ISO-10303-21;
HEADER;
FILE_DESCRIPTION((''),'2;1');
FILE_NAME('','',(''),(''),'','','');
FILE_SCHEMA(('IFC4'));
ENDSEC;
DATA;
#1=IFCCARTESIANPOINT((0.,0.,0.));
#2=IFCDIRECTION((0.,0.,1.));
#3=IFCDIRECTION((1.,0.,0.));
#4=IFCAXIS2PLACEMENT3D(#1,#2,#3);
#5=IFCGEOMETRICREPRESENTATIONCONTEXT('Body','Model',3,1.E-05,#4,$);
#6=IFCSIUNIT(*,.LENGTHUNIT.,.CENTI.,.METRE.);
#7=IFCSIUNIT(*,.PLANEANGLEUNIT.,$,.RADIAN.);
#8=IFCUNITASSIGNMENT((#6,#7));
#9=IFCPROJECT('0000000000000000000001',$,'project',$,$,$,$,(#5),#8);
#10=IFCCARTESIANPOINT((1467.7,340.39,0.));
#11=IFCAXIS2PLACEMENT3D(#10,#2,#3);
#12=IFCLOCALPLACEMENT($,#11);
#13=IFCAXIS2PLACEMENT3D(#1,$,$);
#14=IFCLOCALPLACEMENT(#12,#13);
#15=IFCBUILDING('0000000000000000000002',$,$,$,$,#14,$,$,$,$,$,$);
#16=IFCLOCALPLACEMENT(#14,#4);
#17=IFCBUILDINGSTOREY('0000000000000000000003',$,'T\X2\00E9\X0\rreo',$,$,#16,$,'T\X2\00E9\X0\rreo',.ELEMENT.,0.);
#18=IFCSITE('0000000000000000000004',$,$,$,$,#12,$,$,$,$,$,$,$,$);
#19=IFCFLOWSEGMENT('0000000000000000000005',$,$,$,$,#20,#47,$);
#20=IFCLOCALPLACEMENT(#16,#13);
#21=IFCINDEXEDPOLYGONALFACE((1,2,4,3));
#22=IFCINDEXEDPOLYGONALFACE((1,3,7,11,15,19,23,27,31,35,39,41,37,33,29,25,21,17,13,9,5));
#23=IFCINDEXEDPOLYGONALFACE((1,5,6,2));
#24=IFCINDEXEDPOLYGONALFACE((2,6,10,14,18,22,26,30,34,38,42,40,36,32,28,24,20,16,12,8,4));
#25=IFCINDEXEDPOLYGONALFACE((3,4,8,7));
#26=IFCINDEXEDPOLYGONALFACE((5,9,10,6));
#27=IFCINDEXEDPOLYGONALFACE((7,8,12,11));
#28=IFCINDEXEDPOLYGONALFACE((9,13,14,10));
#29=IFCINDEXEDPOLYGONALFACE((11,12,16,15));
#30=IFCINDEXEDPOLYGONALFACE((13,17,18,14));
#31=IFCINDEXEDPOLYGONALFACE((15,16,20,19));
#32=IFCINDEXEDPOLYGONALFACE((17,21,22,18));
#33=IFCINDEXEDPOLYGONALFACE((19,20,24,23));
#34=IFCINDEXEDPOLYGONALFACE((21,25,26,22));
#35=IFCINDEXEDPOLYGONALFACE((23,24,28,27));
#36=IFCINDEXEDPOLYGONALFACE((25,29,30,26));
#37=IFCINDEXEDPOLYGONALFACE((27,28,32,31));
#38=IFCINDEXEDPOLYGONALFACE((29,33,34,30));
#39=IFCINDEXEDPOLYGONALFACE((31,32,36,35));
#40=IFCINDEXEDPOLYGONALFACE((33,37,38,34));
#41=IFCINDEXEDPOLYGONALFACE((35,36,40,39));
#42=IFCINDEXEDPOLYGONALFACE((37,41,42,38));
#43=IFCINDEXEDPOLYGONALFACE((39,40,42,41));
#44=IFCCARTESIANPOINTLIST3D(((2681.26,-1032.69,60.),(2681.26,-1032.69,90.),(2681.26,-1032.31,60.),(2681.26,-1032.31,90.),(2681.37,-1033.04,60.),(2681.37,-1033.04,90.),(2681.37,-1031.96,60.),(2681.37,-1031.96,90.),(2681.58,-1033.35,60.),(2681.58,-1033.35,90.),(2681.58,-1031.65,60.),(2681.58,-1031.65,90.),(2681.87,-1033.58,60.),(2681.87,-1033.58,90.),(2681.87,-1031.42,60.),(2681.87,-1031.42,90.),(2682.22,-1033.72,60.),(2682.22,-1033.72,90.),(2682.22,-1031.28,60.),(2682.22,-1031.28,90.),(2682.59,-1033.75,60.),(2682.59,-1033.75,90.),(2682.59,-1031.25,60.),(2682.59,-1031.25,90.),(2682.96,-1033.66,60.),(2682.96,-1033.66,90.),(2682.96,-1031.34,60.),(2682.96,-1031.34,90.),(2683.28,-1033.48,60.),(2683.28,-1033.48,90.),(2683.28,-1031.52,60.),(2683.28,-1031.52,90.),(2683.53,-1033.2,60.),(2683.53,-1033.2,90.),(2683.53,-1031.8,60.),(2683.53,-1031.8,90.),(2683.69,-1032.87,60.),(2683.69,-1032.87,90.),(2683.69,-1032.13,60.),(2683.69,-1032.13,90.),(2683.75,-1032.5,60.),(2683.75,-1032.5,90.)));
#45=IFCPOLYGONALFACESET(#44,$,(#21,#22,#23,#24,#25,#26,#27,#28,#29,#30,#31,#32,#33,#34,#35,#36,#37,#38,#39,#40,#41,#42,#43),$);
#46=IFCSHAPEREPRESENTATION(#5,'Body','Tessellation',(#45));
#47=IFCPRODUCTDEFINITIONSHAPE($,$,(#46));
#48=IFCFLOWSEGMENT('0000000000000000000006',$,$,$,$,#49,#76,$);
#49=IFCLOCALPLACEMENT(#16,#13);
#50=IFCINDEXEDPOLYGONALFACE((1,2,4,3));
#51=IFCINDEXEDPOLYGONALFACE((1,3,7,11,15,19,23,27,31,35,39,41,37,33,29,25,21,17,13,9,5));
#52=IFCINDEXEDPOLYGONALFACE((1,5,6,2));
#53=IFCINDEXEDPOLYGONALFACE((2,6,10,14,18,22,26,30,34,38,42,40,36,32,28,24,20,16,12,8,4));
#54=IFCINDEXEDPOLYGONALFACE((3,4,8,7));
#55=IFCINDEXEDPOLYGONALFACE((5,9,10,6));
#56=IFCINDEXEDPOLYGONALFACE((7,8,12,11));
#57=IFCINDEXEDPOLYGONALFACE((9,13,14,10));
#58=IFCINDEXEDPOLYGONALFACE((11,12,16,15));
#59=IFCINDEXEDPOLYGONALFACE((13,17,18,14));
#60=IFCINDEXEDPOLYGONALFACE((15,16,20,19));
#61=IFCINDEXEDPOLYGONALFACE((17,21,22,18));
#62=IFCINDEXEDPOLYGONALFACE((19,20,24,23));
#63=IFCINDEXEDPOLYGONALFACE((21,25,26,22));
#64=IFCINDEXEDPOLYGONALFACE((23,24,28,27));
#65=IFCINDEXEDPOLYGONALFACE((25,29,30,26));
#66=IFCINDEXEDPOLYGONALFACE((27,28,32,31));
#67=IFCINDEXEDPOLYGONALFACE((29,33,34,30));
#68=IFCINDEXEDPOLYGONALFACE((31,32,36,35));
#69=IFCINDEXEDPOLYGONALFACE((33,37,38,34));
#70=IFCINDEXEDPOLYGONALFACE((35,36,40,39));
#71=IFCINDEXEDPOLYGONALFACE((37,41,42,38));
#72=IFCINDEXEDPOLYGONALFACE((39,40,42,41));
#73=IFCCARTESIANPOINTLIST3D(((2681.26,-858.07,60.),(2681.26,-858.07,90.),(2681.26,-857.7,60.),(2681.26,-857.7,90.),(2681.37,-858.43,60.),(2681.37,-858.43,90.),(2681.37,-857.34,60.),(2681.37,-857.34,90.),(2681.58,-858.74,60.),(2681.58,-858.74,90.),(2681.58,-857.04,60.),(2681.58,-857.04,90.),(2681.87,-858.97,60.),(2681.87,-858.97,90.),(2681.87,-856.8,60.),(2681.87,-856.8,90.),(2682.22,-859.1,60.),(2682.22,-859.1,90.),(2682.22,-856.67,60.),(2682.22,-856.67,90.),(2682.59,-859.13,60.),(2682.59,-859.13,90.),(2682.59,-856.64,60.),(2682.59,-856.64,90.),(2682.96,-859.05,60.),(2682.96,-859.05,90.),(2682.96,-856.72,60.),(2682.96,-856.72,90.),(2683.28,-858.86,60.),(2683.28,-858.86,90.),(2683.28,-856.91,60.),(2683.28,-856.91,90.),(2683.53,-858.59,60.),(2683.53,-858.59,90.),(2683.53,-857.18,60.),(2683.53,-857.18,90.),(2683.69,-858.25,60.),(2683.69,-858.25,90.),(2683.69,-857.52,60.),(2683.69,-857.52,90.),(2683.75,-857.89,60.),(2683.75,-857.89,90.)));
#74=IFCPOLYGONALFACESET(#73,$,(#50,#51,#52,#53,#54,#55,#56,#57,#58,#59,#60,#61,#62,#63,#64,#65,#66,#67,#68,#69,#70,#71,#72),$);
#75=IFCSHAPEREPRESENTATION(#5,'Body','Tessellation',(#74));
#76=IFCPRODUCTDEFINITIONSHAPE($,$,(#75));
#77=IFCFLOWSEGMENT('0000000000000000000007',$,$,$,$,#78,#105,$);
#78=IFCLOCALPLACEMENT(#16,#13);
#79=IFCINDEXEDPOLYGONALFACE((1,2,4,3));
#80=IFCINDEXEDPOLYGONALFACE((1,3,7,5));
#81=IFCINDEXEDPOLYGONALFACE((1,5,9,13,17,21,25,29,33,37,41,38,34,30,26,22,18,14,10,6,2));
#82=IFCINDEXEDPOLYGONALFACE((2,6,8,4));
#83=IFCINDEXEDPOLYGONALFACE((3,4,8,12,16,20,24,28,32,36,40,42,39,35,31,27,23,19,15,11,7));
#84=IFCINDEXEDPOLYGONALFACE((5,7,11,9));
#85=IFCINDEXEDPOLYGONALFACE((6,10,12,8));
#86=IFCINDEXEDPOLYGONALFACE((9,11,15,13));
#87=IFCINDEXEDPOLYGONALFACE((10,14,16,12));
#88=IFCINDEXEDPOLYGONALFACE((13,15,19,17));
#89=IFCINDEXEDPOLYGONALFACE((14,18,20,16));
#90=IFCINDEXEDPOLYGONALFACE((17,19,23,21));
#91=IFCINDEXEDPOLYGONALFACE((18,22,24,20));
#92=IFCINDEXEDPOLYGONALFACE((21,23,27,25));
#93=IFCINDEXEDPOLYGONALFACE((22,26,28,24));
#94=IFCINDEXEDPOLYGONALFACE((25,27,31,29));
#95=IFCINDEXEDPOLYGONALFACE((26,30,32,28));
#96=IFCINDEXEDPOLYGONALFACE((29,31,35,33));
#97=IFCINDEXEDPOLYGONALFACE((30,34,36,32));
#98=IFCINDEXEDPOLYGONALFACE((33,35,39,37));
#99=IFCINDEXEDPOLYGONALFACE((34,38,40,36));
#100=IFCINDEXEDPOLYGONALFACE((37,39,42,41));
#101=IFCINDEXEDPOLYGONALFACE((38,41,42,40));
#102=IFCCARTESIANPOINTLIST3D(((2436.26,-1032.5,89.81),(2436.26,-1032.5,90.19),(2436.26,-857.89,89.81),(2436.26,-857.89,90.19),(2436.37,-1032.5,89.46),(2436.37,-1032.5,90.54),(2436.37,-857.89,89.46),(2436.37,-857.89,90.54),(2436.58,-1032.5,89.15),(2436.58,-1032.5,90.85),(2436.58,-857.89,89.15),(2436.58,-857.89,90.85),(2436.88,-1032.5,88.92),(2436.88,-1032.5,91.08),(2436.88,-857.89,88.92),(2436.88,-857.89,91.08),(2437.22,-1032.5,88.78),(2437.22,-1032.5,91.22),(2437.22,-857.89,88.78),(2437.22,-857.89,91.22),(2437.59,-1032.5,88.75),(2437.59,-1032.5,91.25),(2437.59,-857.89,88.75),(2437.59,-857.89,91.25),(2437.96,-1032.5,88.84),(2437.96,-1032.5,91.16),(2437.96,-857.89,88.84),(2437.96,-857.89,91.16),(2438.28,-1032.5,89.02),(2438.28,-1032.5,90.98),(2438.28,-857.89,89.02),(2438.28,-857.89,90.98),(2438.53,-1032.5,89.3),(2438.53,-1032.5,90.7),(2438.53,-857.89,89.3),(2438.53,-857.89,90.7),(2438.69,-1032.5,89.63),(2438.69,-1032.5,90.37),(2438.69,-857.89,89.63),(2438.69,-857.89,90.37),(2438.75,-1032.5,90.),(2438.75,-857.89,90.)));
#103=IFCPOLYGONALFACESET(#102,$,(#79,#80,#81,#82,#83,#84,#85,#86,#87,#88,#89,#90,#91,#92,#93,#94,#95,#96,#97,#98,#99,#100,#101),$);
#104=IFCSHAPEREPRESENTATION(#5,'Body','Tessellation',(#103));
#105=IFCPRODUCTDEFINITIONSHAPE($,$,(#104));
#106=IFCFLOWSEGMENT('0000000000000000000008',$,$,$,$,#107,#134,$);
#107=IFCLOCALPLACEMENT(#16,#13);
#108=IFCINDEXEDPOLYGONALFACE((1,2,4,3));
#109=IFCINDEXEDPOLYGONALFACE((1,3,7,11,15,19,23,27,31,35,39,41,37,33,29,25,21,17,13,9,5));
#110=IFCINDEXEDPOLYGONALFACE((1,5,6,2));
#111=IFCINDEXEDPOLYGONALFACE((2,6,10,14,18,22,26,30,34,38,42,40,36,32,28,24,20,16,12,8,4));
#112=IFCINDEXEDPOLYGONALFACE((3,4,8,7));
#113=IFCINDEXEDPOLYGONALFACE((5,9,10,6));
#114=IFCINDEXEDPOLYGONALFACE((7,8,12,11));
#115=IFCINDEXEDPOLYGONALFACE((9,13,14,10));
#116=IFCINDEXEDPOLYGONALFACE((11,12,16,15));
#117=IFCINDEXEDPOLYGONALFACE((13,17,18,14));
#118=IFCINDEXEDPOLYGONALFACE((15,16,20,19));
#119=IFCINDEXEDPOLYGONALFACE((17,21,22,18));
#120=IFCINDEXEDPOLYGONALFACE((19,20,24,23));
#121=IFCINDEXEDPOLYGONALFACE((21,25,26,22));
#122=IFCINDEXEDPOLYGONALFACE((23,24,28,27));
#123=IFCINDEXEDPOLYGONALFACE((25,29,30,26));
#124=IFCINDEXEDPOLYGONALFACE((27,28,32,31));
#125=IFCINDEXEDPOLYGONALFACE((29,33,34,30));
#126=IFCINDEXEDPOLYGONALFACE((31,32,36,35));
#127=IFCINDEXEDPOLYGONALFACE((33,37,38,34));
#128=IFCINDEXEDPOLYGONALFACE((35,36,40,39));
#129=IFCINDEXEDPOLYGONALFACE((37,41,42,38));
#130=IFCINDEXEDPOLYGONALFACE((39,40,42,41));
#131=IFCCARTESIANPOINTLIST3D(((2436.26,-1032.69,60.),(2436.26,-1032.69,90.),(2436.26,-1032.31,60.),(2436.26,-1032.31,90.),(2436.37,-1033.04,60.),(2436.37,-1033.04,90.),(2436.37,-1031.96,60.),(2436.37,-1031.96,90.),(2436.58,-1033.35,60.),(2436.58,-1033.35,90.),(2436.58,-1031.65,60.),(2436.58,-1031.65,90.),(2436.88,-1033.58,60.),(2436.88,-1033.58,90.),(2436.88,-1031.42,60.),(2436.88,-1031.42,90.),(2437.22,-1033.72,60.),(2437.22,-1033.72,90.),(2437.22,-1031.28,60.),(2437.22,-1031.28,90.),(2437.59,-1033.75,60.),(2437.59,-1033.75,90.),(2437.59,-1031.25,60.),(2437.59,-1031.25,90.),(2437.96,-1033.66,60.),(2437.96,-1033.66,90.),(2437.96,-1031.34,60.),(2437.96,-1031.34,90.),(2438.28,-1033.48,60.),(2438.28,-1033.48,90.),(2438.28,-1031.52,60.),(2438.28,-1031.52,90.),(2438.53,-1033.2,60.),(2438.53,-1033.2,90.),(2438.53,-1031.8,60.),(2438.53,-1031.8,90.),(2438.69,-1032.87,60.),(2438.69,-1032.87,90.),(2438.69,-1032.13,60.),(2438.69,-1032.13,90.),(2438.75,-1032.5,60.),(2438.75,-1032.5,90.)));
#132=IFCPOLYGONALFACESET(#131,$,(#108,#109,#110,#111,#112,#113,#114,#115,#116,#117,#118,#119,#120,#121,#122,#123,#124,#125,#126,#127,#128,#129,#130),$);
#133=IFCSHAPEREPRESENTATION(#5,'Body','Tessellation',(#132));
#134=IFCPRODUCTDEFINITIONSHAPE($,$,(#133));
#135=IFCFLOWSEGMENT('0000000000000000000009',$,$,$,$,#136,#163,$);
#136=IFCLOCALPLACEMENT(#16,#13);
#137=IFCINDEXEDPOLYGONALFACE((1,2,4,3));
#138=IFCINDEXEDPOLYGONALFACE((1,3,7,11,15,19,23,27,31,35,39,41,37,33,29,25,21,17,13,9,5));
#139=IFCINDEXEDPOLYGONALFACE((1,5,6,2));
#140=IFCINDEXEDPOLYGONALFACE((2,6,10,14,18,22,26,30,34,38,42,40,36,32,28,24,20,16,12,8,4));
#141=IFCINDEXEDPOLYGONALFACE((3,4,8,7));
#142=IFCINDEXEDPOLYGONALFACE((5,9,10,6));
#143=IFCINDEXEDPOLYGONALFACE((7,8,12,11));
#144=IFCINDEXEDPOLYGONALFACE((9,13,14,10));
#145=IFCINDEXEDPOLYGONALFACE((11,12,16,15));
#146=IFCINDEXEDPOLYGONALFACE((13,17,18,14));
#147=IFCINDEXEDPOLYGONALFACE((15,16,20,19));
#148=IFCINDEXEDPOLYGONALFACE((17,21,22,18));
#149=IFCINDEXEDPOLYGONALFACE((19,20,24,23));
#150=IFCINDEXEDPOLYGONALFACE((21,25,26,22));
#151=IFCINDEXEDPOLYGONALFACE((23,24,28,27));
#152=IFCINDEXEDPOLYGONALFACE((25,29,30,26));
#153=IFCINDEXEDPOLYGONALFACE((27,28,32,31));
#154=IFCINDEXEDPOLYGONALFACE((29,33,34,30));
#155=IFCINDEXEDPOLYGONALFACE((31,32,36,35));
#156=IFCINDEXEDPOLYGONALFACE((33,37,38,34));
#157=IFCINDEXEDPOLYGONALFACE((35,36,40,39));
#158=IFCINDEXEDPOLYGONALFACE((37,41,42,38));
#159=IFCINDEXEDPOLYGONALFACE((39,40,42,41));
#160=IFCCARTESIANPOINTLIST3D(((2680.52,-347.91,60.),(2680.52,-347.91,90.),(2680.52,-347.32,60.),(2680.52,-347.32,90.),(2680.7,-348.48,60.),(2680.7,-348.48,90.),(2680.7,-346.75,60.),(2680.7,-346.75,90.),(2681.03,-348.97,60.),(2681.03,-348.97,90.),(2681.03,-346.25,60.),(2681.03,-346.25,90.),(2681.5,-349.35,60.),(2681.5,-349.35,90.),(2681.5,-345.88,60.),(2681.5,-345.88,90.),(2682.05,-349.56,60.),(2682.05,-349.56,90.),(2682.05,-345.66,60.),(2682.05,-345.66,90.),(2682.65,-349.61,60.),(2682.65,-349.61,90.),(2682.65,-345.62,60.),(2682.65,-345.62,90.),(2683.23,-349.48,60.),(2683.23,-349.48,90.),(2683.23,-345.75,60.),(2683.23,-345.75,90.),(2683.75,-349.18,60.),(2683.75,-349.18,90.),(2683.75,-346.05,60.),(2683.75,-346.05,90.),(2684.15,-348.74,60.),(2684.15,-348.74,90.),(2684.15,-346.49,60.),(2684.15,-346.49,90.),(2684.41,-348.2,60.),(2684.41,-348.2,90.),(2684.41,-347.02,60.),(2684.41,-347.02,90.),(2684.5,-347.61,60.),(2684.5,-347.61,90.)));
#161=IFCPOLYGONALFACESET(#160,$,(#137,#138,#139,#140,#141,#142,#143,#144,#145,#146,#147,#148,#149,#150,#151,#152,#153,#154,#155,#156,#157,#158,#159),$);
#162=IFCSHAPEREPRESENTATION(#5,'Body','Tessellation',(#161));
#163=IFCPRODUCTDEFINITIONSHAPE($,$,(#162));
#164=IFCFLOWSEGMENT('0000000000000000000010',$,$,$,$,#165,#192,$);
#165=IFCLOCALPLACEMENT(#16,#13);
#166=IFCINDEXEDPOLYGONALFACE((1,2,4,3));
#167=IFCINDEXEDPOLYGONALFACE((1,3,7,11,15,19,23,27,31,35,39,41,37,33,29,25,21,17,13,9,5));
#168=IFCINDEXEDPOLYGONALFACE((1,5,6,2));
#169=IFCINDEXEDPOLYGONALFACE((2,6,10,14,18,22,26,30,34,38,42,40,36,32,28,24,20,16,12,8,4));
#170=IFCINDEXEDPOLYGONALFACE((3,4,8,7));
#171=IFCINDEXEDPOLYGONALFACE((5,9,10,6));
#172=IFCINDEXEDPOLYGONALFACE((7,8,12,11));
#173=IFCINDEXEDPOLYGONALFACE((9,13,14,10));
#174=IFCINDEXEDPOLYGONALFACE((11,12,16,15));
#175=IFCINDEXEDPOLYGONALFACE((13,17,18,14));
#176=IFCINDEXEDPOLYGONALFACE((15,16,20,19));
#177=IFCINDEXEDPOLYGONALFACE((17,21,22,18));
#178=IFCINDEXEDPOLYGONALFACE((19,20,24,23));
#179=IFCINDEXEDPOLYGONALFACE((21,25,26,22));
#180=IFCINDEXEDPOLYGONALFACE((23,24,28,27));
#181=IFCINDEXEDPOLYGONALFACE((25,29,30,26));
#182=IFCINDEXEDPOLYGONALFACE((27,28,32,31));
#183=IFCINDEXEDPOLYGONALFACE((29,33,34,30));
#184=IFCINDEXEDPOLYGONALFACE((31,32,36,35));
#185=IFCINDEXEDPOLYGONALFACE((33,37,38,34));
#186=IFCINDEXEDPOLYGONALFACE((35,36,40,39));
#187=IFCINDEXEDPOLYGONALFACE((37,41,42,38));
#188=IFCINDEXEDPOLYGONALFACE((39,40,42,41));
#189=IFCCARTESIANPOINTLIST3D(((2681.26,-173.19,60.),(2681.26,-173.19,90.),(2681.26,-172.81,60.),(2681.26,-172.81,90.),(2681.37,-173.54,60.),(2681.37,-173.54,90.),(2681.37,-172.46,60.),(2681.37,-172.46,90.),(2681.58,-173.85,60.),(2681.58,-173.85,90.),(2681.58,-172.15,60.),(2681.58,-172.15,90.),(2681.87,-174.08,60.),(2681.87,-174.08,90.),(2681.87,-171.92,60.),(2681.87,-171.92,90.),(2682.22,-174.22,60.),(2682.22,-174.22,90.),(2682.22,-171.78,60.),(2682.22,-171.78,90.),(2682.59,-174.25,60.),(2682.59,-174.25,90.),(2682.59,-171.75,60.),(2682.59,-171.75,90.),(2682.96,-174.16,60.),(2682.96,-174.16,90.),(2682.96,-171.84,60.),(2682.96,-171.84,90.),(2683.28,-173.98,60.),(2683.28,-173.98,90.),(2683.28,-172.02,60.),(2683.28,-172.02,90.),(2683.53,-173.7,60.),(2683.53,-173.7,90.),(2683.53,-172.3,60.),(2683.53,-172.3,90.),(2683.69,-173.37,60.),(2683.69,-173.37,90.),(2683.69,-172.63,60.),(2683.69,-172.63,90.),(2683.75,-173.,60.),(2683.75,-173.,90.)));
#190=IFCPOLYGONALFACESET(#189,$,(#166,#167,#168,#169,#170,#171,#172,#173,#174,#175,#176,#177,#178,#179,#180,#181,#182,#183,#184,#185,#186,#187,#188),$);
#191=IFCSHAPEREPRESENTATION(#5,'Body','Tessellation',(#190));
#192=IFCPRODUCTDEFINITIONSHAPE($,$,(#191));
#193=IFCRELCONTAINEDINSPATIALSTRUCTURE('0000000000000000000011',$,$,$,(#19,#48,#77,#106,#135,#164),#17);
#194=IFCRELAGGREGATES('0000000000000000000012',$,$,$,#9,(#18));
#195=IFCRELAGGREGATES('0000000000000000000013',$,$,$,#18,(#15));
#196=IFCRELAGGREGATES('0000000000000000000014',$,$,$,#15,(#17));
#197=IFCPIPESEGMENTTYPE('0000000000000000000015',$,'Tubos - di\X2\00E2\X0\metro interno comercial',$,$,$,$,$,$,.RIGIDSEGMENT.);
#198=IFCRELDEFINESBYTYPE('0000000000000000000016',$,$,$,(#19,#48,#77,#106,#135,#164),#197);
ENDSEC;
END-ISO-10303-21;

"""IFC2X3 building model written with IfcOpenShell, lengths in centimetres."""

from ifc_helpers import new_model, si_unit, frame, origin, origin_with_axes, origin_2d_with_axis, place, context, project, spatial, circle, extrude, type_object, element, save


model = new_model("IFC2X3")

# Units and contexts
model_context = context("Model", 3, precision=1e-05, world=origin_with_axes(), identifier="Body")
ifc_project = project(units=[si_unit("LENGTHUNIT", "METRE", prefix="CENTI"), si_unit("PLANEANGLEUNIT", "RADIAN")], contexts=[model_context])

# Site, building, storey
site_placement = place(None, frame((1467.7, 340.39, 0.0), z_axis=(0.0, 0.0, 1.0), x_axis=(1.0, 0.0, 0.0)))
site = spatial("IfcSite", under=ifc_project, at=site_placement)
building_placement = place(site_placement, origin())
building = spatial("IfcBuilding", under=site, at=building_placement)
storey_placement = place(building_placement, origin_with_axes())
storey = spatial("IfcBuildingStorey", under=building, at=storey_placement, Name="Térreo", LongName="Térreo", CompositionType="ELEMENT", Elevation=0.0)

# Flow segments
pipe_segment_type = type_object("IfcPipeSegmentType", Name="Tubos - diâmetro interno comercial", PredefinedType="RIGIDSEGMENT")
for number, where, z_axis, x_axis in (
    (1, (2682.5, -1032.5, 90.0), (0.0, 0.0, 1.0), (1.0, 0.0, 0.0)),
    (2, (2682.5, -857.89, 90.0), (0.0, 0.0, 1.0), (1.0, 0.0, 0.0)),
):
    element("IfcFlowSegment", number, at=place(storey_placement, frame(where, z_axis=z_axis, x_axis=x_axis)), inside=storey, type_object=pipe_segment_type, context=model_context, shape_type="SolidModel", body=[
        extrude(circle(Radius=1.25, at=origin_2d_with_axis()), frame((0.0, 0.0, 0.0), z_axis=(0.0, 0.0, -1.0), x_axis=(1.0, 0.0, 0.0)), (0.0, 0.0, 1.0), 30.0),
    ])
flow_segment_1_placement = place(storey_placement, frame((2437.5, -945.19, 91.25), z_axis=(0.0, 0.0, 1.0), x_axis=(1.0, 0.0, 0.0)))
element("IfcFlowSegment", 3, at=flow_segment_1_placement, inside=storey, type_object=pipe_segment_type, context=model_context, shape_type="SolidModel", body=[
    extrude(circle(Radius=1.25, at=origin_2d_with_axis()), frame((0.0, 87.31, -1.25), z_axis=(0.0, -1.0, 0.0), x_axis=(1.0, 0.0, 0.0)), (0.0, 0.0, 1.0), 174.61),
])
flow_segment_2_placement = place(storey_placement, frame((2437.5, -1032.5, 90.0), z_axis=(0.0, 0.0, 1.0), x_axis=(1.0, 0.0, 0.0)))
element("IfcFlowSegment", 4, at=flow_segment_2_placement, inside=storey, type_object=pipe_segment_type, context=model_context, shape_type="SolidModel", body=[
    extrude(circle(Radius=1.25, at=origin_2d_with_axis()), frame((0.0, 0.0, 0.0), z_axis=(0.0, 0.0, -1.0), x_axis=(1.0, 0.0, 0.0)), (0.0, 0.0, 1.0), 30.0),
])
flow_segment_3_placement = place(storey_placement, frame((2682.5, -347.61, 90.0), z_axis=(0.0, 0.0, 1.0), x_axis=(1.0, 0.0, 0.0)))
element("IfcFlowSegment", 5, at=flow_segment_3_placement, inside=storey, type_object=pipe_segment_type, context=model_context, shape_type="SolidModel", body=[
    extrude(circle(Radius=2.0, at=origin_2d_with_axis()), frame((0.0, 0.0, 0.0), z_axis=(0.0, 0.0, -1.0), x_axis=(1.0, 0.0, 0.0)), (0.0, 0.0, 1.0), 30.0),
])
for number, where, z_axis, x_axis in (
    (6, (2682.5, -173.0, 90.0), (0.0, 0.0, 1.0), (1.0, 0.0, 0.0)),
):
    element("IfcFlowSegment", number, at=place(storey_placement, frame(where, z_axis=z_axis, x_axis=x_axis)), inside=storey, type_object=pipe_segment_type, context=model_context, shape_type="SolidModel", body=[
        extrude(circle(Radius=1.25, at=origin_2d_with_axis()), frame((0.0, 0.0, 0.0), z_axis=(0.0, 0.0, -1.0), x_axis=(1.0, 0.0, 0.0)), (0.0, 0.0, 1.0), 30.0),
    ])

save(model, "model.ifc")
